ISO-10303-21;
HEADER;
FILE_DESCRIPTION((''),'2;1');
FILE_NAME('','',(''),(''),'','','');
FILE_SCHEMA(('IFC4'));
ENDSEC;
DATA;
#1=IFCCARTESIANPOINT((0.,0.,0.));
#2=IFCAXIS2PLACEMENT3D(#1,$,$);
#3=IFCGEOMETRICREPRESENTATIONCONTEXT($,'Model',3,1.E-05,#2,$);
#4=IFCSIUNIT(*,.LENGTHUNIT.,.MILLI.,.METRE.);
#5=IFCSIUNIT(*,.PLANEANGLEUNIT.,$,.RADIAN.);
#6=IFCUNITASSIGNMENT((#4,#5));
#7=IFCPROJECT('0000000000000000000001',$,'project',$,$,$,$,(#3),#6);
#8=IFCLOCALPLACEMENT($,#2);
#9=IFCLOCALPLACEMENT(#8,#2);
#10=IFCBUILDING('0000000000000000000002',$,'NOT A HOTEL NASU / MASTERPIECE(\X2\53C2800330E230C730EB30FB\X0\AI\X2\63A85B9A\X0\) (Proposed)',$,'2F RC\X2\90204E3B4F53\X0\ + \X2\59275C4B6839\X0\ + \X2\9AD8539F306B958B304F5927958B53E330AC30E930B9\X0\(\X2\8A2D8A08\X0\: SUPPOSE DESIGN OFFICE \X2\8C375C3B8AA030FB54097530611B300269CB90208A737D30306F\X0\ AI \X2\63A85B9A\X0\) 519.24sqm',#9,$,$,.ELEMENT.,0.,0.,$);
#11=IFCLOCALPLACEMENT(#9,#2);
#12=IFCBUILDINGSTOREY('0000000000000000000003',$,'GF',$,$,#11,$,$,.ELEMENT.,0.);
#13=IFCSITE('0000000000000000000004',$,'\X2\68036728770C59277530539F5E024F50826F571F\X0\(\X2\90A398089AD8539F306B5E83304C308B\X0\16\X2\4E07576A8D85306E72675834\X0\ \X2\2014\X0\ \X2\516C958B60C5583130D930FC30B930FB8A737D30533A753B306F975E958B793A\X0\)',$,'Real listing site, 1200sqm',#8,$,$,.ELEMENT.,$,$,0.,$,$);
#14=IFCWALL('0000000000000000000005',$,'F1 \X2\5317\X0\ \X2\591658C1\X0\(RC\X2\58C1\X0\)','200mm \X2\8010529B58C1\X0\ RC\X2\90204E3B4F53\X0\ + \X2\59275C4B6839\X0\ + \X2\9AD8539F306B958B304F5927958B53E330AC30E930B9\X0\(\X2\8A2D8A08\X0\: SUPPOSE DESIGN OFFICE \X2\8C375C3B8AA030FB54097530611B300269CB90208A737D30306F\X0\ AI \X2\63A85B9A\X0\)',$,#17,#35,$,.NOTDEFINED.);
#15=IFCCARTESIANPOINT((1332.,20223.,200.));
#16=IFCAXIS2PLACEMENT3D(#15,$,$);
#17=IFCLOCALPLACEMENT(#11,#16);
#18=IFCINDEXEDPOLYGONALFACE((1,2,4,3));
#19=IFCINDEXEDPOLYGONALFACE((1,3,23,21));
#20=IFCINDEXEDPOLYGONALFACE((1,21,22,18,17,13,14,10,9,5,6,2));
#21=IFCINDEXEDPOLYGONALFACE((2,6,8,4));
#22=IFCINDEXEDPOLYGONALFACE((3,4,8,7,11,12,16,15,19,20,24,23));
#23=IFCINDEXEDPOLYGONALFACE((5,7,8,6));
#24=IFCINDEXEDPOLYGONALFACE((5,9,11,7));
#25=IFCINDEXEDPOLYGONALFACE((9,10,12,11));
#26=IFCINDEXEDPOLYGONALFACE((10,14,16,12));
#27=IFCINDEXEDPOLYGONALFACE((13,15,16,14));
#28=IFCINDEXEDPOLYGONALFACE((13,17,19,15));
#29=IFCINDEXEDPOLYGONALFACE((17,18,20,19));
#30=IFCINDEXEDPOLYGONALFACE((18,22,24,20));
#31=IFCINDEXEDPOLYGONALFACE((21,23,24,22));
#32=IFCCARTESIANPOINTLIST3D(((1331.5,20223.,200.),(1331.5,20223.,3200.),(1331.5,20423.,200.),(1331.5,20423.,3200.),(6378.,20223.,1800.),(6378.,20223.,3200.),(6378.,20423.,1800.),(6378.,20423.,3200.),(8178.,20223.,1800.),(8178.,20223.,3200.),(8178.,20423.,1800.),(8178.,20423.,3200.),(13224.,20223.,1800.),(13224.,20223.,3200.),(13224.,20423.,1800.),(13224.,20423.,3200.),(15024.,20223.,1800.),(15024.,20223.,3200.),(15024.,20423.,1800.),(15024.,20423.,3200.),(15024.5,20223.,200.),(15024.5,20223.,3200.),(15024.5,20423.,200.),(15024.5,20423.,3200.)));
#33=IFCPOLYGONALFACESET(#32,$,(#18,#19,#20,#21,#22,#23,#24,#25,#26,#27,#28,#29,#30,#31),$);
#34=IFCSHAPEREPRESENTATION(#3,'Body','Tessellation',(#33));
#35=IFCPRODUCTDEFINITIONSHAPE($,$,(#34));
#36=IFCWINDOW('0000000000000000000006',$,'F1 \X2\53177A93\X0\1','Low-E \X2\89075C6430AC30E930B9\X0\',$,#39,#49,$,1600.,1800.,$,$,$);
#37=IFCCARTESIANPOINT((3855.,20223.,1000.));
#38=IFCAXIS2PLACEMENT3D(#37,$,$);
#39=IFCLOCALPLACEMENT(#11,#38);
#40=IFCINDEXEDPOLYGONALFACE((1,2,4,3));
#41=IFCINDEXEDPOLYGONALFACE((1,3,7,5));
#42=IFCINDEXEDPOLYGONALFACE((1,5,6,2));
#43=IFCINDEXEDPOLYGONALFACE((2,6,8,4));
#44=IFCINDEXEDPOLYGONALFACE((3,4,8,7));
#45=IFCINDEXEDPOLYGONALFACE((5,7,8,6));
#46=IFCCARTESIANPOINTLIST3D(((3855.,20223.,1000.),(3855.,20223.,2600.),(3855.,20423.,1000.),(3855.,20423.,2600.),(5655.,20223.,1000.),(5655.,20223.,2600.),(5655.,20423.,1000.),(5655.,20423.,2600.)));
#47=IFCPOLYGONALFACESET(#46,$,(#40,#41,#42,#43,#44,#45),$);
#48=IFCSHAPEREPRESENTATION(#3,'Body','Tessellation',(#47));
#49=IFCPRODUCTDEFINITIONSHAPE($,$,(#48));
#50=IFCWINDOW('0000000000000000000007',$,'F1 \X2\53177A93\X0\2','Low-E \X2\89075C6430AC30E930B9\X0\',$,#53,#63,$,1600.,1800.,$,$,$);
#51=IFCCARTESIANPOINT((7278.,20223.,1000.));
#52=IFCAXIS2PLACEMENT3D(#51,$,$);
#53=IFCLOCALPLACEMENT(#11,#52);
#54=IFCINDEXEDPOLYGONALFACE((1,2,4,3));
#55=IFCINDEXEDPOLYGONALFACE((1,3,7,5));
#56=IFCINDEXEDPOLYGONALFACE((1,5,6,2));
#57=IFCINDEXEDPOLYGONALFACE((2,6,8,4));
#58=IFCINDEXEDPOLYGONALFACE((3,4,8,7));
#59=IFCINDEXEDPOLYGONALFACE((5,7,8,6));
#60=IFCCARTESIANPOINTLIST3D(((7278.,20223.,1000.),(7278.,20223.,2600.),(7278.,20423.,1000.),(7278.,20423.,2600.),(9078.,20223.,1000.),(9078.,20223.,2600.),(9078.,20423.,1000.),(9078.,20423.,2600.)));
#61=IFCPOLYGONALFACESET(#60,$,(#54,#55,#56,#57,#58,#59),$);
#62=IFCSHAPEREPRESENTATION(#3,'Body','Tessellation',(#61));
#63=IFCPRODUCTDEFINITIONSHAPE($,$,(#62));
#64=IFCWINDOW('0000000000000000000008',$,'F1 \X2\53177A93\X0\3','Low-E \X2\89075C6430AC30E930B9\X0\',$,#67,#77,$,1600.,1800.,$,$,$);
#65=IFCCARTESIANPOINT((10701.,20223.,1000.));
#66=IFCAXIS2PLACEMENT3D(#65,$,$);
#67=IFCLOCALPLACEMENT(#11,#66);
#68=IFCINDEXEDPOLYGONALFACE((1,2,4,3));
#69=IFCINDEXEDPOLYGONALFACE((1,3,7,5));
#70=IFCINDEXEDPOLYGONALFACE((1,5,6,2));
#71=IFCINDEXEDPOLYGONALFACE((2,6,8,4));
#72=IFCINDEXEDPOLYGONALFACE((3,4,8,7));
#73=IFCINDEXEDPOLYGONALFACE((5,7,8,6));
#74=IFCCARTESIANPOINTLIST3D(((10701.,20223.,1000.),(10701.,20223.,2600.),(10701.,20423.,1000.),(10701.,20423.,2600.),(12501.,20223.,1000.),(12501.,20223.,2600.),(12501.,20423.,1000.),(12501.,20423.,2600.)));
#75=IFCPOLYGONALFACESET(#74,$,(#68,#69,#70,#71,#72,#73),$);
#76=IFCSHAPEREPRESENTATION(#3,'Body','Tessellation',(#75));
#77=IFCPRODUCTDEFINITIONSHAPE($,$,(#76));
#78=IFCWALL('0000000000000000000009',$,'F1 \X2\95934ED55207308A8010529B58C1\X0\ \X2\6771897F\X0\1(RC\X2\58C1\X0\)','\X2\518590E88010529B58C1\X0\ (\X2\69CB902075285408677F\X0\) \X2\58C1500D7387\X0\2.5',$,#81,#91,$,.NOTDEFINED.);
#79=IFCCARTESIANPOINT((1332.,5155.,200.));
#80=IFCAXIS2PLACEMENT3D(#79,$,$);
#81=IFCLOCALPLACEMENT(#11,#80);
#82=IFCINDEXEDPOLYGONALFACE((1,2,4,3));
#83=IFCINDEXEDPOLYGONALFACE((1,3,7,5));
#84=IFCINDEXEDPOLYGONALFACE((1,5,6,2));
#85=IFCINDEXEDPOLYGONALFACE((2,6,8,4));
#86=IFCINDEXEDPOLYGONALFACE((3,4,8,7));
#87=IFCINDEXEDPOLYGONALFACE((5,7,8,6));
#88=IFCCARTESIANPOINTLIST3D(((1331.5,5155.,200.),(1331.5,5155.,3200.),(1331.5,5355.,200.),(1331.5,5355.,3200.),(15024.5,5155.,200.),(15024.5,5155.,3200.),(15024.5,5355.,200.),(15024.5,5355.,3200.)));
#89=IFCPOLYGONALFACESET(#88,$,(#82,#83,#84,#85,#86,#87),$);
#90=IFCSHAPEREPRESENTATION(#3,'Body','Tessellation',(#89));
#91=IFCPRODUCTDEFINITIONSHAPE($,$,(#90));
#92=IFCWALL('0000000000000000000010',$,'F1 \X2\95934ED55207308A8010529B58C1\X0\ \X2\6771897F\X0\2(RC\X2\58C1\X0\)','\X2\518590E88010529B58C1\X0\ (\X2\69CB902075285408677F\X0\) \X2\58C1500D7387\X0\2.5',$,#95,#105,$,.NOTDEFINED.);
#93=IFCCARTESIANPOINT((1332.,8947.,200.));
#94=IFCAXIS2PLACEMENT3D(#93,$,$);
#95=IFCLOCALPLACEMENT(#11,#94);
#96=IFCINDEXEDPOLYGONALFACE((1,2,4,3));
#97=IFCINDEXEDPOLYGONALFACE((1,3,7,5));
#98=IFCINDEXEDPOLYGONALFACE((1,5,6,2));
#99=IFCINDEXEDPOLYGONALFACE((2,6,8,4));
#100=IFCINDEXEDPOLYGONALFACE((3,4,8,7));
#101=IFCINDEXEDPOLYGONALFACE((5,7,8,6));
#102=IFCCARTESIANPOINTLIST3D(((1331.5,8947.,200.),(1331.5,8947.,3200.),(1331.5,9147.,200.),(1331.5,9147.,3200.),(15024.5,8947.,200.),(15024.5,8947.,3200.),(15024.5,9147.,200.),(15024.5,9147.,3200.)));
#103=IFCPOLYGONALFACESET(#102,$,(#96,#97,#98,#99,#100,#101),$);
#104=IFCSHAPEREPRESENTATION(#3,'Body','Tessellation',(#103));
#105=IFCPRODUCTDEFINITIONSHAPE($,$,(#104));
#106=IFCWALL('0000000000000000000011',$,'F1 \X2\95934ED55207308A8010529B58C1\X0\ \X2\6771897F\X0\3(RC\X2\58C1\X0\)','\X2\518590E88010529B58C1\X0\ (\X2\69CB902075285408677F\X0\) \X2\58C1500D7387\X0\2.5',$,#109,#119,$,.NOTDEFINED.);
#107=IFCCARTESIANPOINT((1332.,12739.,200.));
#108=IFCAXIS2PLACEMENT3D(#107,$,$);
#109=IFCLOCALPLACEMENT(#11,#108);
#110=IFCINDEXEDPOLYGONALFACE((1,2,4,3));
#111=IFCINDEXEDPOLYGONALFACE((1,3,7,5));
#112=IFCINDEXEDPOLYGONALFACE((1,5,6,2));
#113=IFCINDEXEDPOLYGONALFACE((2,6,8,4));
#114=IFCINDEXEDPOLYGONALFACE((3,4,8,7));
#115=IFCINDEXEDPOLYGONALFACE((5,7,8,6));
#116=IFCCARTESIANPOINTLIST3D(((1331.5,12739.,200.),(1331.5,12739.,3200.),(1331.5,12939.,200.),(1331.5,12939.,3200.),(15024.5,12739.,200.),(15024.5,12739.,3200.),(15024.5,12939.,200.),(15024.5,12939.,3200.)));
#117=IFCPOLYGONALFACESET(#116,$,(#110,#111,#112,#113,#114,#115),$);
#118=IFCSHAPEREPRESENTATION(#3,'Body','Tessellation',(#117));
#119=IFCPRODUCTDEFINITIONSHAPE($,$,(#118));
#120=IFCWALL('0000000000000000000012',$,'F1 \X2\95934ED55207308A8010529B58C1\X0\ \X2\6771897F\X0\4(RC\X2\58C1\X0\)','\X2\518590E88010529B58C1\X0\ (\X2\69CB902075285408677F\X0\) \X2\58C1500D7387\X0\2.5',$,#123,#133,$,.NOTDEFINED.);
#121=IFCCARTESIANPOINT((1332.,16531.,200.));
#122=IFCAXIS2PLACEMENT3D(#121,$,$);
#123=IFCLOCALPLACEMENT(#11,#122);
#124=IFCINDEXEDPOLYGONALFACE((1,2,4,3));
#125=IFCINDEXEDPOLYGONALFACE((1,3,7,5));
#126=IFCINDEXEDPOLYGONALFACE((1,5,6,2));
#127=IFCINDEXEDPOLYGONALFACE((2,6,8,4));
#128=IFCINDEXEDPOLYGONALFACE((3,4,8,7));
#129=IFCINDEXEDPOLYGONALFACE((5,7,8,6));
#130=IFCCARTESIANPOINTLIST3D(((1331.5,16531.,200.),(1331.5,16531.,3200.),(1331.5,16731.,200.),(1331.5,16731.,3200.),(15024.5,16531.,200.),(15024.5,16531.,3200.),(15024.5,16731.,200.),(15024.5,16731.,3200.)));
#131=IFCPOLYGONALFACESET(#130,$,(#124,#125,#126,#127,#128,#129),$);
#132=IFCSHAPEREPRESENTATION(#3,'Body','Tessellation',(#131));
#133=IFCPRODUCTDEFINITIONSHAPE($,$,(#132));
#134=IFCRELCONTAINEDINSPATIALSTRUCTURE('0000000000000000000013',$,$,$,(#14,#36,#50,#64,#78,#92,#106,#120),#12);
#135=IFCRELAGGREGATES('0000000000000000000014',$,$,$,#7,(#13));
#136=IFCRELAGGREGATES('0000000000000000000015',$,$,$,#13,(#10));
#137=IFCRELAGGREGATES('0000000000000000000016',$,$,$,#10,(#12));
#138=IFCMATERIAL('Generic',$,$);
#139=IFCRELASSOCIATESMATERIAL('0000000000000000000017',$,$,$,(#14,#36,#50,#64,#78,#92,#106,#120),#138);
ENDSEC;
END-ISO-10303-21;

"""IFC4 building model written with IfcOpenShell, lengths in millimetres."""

from ifc_helpers import new_model, si_unit, frame, frame_2d, origin, place, context, project, spatial, rectangle, extrude, material, element, fill, save


model = new_model("IFC4")

# Units and contexts
model_context = context("Model", 3, precision=1e-05, world=origin())
ifc_project = project(units=[si_unit("LENGTHUNIT", "METRE", prefix="MILLI"), si_unit("PLANEANGLEUNIT", "RADIAN")], contexts=[model_context])

# Site, building, storey
site_placement = place(None, origin())
site = spatial("IfcSite", under=ifc_project, at=site_placement, Name="栃木県大田原市佐良土(那須高原に広がる16万坪超の牧場 — 公開情報ベース・詳細区画は非開示)", ObjectType="Real listing site, 1200sqm", CompositionType="ELEMENT", RefElevation=0.0)
building_placement = place(site_placement, origin())
building = spatial("IfcBuilding", under=site, at=building_placement, Name="NOT A HOTEL NASU / MASTERPIECE(参考モデル・AI推定) (Proposed)", ObjectType="2F RC造主体 + 大屋根 + 高原に開く大開口ガラス(設計: SUPPOSE DESIGN OFFICE 谷尻誠・吉田愛。構造詳細は AI 推定) 519.24sqm", CompositionType="ELEMENT", ElevationOfRefHeight=0.0, ElevationOfTerrain=0.0)
storey_placement = place(building_placement, origin())
storey = spatial("IfcBuildingStorey", under=building, at=storey_placement, Name="GF", CompositionType="ELEMENT", Elevation=0.0)

# Wall, openings, windows
ifc_material_1 = material(Name="Generic")
wall_1_placement = place(storey_placement, frame((1332.0, 20223.0, 200.0)))
wall_1 = element("IfcWall", 1, at=wall_1_placement, inside=storey, material=ifc_material_1, Name="F1 北 外壁(RC壁)", Description="200mm 耐力壁 RC造主体 + 大屋根 + 高原に開く大開口ガラス(設計: SUPPOSE DESIGN OFFICE 谷尻誠・吉田愛。構造詳細は AI 推定)", PredefinedType="NOTDEFINED", context=model_context, shape_type="SweptSolid", body=[
    extrude(rectangle(XDim=13693.0, YDim=200.0, at=frame_2d((6846.0, 100.0))), frame((1332.0, 20223.0, 200.0)), (0.0, 0.0, 1.0), 3000.0),
])
opening_1_placement = place(storey_placement, frame((3855.0, 20223.0, 1000.0)))
opening_1 = element("IfcOpeningElement", 2, at=opening_1_placement, cuts=wall_1, PredefinedType="NOTDEFINED", context=model_context, shape_type="SweptSolid", body=[
    extrude(rectangle(XDim=1800.0, YDim=200.0, at=frame_2d((900.0, 100.0))), frame((3855.0, 20223.0, 1000.0)), (0.0, 0.0, 1.0), 1600.0),
])
opening_2_placement = place(storey_placement, frame((7278.0, 20223.0, 1000.0)))
opening_2 = element("IfcOpeningElement", 3, at=opening_2_placement, cuts=wall_1, PredefinedType="NOTDEFINED", context=model_context, shape_type="SweptSolid", body=[
    extrude(rectangle(XDim=1800.0, YDim=200.0, at=frame_2d((900.0, 100.0))), frame((7278.0, 20223.0, 1000.0)), (0.0, 0.0, 1.0), 1600.0),
])
opening_3_placement = place(storey_placement, frame((10701.0, 20223.0, 1000.0)))
opening_3 = element("IfcOpeningElement", 4, at=opening_3_placement, cuts=wall_1, PredefinedType="NOTDEFINED", context=model_context, shape_type="SweptSolid", body=[
    extrude(rectangle(XDim=1800.0, YDim=200.0, at=frame_2d((900.0, 100.0))), frame((10701.0, 20223.0, 1000.0)), (0.0, 0.0, 1.0), 1600.0),
])
window_1_placement = place(storey_placement, frame((3855.0, 20223.0, 1000.0)))
window_1 = element("IfcWindow", 5, at=window_1_placement, inside=storey, material=ifc_material_1, Name="F1 北窓1", Description="Low-E 複層ガラス", OverallHeight=1600.0, OverallWidth=1800.0, context=model_context, shape_type="SweptSolid", body=[
    extrude(rectangle(XDim=1800.0, YDim=200.0, at=frame_2d((900.0, 100.0))), frame((3855.0, 20223.0, 1000.0)), (0.0, 0.0, 1.0), 1600.0),
])
fill(opening_1, window_1)
window_2_placement = place(storey_placement, frame((7278.0, 20223.0, 1000.0)))
window_2 = element("IfcWindow", 6, at=window_2_placement, inside=storey, material=ifc_material_1, Name="F1 北窓2", Description="Low-E 複層ガラス", OverallHeight=1600.0, OverallWidth=1800.0, context=model_context, shape_type="SweptSolid", body=[
    extrude(rectangle(XDim=1800.0, YDim=200.0, at=frame_2d((900.0, 100.0))), frame((7278.0, 20223.0, 1000.0)), (0.0, 0.0, 1.0), 1600.0),
])
fill(opening_2, window_2)
window_3_placement = place(storey_placement, frame((10701.0, 20223.0, 1000.0)))
window_3 = element("IfcWindow", 7, at=window_3_placement, inside=storey, material=ifc_material_1, Name="F1 北窓3", Description="Low-E 複層ガラス", OverallHeight=1600.0, OverallWidth=1800.0, context=model_context, shape_type="SweptSolid", body=[
    extrude(rectangle(XDim=1800.0, YDim=200.0, at=frame_2d((900.0, 100.0))), frame((10701.0, 20223.0, 1000.0)), (0.0, 0.0, 1.0), 1600.0),
])
fill(opening_3, window_3)

# Walls
wall_2_placement = place(storey_placement, frame((1332.0, 5155.0, 200.0)))
element("IfcWall", 8, at=wall_2_placement, inside=storey, material=ifc_material_1, Name="F1 間仕切り耐力壁 東西1(RC壁)", Description="内部耐力壁 (構造用合板) 壁倍率2.5", PredefinedType="NOTDEFINED", context=model_context, shape_type="SweptSolid", body=[
    extrude(rectangle(XDim=13693.0, YDim=200.0, at=frame_2d((6846.0, 100.0))), frame((1332.0, 5155.0, 200.0)), (0.0, 0.0, 1.0), 3000.0),
])
wall_3_placement = place(storey_placement, frame((1332.0, 8947.0, 200.0)))
element("IfcWall", 9, at=wall_3_placement, inside=storey, material=ifc_material_1, Name="F1 間仕切り耐力壁 東西2(RC壁)", Description="内部耐力壁 (構造用合板) 壁倍率2.5", PredefinedType="NOTDEFINED", context=model_context, shape_type="SweptSolid", body=[
    extrude(rectangle(XDim=13693.0, YDim=200.0, at=frame_2d((6846.0, 100.0))), frame((1332.0, 8947.0, 200.0)), (0.0, 0.0, 1.0), 3000.0),
])
wall_4_placement = place(storey_placement, frame((1332.0, 12739.0, 200.0)))
element("IfcWall", 10, at=wall_4_placement, inside=storey, material=ifc_material_1, Name="F1 間仕切り耐力壁 東西3(RC壁)", Description="内部耐力壁 (構造用合板) 壁倍率2.5", PredefinedType="NOTDEFINED", context=model_context, shape_type="SweptSolid", body=[
    extrude(rectangle(XDim=13693.0, YDim=200.0, at=frame_2d((6846.0, 100.0))), frame((1332.0, 12739.0, 200.0)), (0.0, 0.0, 1.0), 3000.0),
])
wall_5_placement = place(storey_placement, frame((1332.0, 16531.0, 200.0)))
element("IfcWall", 11, at=wall_5_placement, inside=storey, material=ifc_material_1, Name="F1 間仕切り耐力壁 東西4(RC壁)", Description="内部耐力壁 (構造用合板) 壁倍率2.5", PredefinedType="NOTDEFINED", context=model_context, shape_type="SweptSolid", body=[
    extrude(rectangle(XDim=13693.0, YDim=200.0, at=frame_2d((6846.0, 100.0))), frame((1332.0, 16531.0, 200.0)), (0.0, 0.0, 1.0), 3000.0),
])

save(model, "model.ifc")
